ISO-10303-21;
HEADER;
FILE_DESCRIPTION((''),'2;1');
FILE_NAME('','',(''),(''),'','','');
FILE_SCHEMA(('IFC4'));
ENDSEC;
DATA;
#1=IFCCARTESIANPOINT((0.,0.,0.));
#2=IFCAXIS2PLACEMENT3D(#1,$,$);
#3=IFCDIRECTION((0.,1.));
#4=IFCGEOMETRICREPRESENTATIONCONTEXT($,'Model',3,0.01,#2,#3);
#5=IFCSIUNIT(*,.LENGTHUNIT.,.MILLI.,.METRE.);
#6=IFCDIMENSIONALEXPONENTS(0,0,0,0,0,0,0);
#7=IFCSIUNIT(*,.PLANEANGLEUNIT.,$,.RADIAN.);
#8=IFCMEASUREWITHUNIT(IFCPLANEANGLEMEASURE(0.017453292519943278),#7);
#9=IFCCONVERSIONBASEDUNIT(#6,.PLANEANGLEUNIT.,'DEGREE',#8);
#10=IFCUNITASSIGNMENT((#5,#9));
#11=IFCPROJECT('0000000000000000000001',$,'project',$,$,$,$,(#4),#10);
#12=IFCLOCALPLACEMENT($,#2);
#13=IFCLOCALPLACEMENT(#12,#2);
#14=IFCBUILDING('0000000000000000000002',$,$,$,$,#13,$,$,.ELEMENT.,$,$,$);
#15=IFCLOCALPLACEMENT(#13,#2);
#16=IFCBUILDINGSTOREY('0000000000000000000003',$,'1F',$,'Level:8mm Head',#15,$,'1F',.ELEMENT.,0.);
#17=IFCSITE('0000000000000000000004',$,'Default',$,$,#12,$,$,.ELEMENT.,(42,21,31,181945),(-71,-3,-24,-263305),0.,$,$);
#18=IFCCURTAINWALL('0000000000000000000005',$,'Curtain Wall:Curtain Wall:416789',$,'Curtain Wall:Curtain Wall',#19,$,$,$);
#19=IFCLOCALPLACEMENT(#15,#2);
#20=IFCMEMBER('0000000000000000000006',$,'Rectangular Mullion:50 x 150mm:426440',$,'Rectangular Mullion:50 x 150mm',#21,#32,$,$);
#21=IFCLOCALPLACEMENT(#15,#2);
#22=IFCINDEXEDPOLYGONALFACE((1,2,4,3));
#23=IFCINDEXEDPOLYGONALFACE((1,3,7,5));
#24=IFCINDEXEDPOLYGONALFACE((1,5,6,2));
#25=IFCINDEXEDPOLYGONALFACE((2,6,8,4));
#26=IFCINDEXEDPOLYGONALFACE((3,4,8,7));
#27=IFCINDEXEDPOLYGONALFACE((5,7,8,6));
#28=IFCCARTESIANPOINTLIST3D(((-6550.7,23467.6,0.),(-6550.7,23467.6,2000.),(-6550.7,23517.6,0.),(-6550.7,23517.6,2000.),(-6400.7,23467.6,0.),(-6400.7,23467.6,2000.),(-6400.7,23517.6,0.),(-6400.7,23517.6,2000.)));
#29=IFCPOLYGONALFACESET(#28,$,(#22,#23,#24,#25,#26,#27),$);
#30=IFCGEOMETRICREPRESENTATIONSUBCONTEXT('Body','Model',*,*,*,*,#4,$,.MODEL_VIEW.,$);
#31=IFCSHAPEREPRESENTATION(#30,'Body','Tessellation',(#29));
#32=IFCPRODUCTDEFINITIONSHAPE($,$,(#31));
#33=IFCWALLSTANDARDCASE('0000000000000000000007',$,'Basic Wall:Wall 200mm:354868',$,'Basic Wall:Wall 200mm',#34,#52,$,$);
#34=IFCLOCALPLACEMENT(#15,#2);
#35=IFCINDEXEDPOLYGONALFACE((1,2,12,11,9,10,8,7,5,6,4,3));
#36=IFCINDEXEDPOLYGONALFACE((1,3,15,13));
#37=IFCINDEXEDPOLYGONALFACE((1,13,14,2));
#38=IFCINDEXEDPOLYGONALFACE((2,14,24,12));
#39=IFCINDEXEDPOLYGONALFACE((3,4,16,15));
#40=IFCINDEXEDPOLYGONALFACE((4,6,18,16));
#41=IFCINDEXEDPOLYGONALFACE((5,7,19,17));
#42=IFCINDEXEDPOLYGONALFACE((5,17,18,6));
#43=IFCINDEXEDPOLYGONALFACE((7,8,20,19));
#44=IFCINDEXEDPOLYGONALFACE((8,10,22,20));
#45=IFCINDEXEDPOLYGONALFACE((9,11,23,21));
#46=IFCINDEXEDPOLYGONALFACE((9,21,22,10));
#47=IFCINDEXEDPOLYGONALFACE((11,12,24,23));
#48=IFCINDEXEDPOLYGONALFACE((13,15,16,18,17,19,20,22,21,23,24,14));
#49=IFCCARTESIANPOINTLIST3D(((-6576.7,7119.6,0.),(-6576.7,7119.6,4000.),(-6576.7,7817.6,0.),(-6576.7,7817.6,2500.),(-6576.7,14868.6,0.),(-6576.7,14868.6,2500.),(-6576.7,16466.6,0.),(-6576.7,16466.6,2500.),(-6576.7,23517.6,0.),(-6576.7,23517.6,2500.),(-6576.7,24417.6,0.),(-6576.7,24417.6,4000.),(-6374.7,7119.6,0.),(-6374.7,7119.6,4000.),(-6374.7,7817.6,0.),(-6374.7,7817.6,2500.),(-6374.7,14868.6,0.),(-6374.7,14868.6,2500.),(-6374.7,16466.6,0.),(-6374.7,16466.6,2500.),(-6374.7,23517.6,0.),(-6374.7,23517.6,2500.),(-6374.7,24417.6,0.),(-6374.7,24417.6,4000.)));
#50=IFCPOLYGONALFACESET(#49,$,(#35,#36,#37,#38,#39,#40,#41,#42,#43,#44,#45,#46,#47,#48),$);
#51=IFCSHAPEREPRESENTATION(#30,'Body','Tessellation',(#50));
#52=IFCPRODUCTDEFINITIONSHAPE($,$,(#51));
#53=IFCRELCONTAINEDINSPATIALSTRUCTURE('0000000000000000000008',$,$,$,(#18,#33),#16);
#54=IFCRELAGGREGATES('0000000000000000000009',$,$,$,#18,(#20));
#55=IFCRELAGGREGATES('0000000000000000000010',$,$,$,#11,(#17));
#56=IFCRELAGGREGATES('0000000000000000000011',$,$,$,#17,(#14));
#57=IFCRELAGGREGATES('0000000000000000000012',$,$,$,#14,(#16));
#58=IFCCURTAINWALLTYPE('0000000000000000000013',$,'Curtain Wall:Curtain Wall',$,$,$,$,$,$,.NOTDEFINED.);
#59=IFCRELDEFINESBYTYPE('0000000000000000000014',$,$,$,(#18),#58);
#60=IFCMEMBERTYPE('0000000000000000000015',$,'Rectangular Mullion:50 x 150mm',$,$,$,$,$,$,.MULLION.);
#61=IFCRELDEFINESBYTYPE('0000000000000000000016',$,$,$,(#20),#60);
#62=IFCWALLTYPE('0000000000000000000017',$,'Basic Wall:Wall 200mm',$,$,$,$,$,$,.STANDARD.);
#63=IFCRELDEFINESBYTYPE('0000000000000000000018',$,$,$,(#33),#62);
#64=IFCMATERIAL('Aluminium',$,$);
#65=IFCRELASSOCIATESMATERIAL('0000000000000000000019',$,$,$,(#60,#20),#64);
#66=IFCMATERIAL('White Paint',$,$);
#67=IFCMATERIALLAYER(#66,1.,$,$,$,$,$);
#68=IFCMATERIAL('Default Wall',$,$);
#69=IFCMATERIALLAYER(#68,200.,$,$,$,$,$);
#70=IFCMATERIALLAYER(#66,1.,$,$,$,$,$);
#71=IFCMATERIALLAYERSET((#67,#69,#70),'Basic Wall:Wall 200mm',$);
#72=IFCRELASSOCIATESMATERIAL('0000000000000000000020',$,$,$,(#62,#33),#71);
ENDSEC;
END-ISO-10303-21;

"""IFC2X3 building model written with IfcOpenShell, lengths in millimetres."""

from ifc_helpers import new_model, entity, si_unit, converted_unit, direction, frame, frame_2d, origin, origin_2d_with_axis, place, context, subcontext, project, spatial, rectangle, extrude, source, transform, mapped, material, layer, layer_set, layer_usage, type_object, type_shapes, element, aggregate, save


model = new_model("IFC2X3")

# Units and contexts
model_context = context("Model", 3, precision=0.01, world=origin(), true_north=direction((0.0, 1.0)))
body_context = subcontext(model_context, "Body", "Model", "MODEL_VIEW")
ifc_project = project(units=[si_unit("LENGTHUNIT", "METRE", prefix="MILLI"), converted_unit("PLANEANGLEUNIT", "DEGREE", entity("IfcPlaneAngleMeasure", 0.017453292519943278), si_unit("PLANEANGLEUNIT", "RADIAN"), dimensions=[0, 0, 0, 0, 0, 0, 0])], contexts=[model_context])

# Site, building, storey
site_placement = place(None, origin())
site = spatial("IfcSite", under=ifc_project, at=site_placement, Name="Default", CompositionType="ELEMENT", RefLatitude=(42, 21, 31, 181945), RefLongitude=(-71, -3, -24, -263305), RefElevation=0.0)
building_placement = place(site_placement, origin())
building = spatial("IfcBuilding", under=site, at=building_placement, CompositionType="ELEMENT")
storey_placement = place(building_placement, origin())
storey = spatial("IfcBuildingStorey", under=building, at=storey_placement, Name="1F", ObjectType="Level:8mm Head", LongName="1F", CompositionType="ELEMENT", Elevation=0.0)

# Curtain wall, member
curtain_wall_type = type_object("IfcCurtainWallType", Name="Curtain Wall:Curtain Wall", PredefinedType="NOTDEFINED")
curtain_wall_placement = place(storey_placement, origin())
curtain_wall = element("IfcCurtainWall", 1, at=curtain_wall_placement, inside=storey, type_object=curtain_wall_type, Name="Curtain Wall:Curtain Wall:416789", ObjectType="Curtain Wall:Curtain Wall")
ifc_material_1 = material(Name="Aluminium")
member_type = type_object("IfcMemberType", Name="Rectangular Mullion:50 x 150mm", PredefinedType="MULLION", material=ifc_material_1)
shared_shape = source(origin(), body_context, "Body", "SweptSolid", [
    extrude(rectangle(XDim=50.0, YDim=150.0, at=origin_2d_with_axis()), frame((-25.0, 0.0, -2000.0), z_axis=(0.0, 0.0, 1.0), x_axis=(-1.0, 0.0, 0.0)), (0.0, 0.0, 1.0), 2000.0),
])
type_shapes(member_type, [shared_shape])
member_placement = place(curtain_wall_placement, frame((-6475.7, 23517.6, 2000.0), z_axis=(0.0, 0.0, 1.0), x_axis=(0.0, 1.0, 0.0)))
member = element("IfcMember", 2, at=member_placement, type_object=member_type, material=ifc_material_1, Name="Rectangular Mullion:50 x 150mm:426440", ObjectType="Rectangular Mullion:50 x 150mm", context=body_context, shape_type="MappedRepresentation", body=[
    mapped(shared_shape, transform((0.0, 0.0, 0.0), scale=1.0)),
])
aggregate(curtain_wall, [member])

# Wall, openings
ifc_material_2 = material(Name="White Paint")
ifc_layer_1 = layer(ifc_material_2, 1.0)
ifc_material_3 = material(Name="Default Wall")
ifc_layer_2 = layer(ifc_material_3, 200.0)
ifc_layer_3 = layer(ifc_material_2, 1.0)
ifc_layer_set_1 = layer_set([ifc_layer_1, ifc_layer_2, ifc_layer_3], Name="Basic Wall:Wall 200mm")
ifc_layer_usage_1 = layer_usage(ifc_layer_set_1, "AXIS2", "NEGATIVE", 101.0)
wall_type_1 = type_object("IfcWallType", Name="Basic Wall:Wall 200mm", PredefinedType="STANDARD", material=ifc_layer_set_1)
wall_1_placement = place(storey_placement, frame((-6475.7, 24417.6, 0.0), z_axis=(0.0, 0.0, 1.0), x_axis=(0.0, -1.0, 0.0)))
wall_1 = element("IfcWallStandardCase", 3, at=wall_1_placement, inside=storey, type_object=wall_type_1, material=ifc_layer_usage_1, Name="Basic Wall:Wall 200mm:354868", ObjectType="Basic Wall:Wall 200mm", context=body_context, shape_type="SweptSolid", body=[
    extrude(rectangle(XDim=17298.0, YDim=202.0, at=frame_2d((8649.0, 0.0), x_axis=(-1.0, 0.0))), origin(), (0.0, 0.0, 1.0), 4000.0),
])
opening_1_placement = place(wall_1_placement, origin())
element("IfcOpeningElement", 4, at=opening_1_placement, cuts=wall_1, ObjectType="Opening", context=body_context, shape_type="SweptSolid", body=[
    extrude(rectangle(XDim=2500.0, YDim=7051.0, at=frame_2d((0.0, 0.0), x_axis=(0.0, 1.0))), frame((4425.5, 101.0, 1250.0), z_axis=(0.0, -1.0, 0.0), x_axis=(1.0, 0.0, 0.0)), (0.0, 0.0, 1.0), 202.0),
])
opening_2_placement = place(wall_1_placement, origin())
element("IfcOpeningElement", 5, at=opening_2_placement, cuts=wall_1, ObjectType="Opening", context=body_context, shape_type="SweptSolid", body=[
    extrude(rectangle(XDim=2500.0, YDim=7051.0, at=frame_2d((0.0, 0.0), x_axis=(0.0, 1.0))), frame((13074.5, 101.0, 1250.0), z_axis=(0.0, -1.0, 0.0), x_axis=(1.0, 0.0, 0.0)), (0.0, 0.0, 1.0), 202.0),
])

save(model, "model.ifc")
